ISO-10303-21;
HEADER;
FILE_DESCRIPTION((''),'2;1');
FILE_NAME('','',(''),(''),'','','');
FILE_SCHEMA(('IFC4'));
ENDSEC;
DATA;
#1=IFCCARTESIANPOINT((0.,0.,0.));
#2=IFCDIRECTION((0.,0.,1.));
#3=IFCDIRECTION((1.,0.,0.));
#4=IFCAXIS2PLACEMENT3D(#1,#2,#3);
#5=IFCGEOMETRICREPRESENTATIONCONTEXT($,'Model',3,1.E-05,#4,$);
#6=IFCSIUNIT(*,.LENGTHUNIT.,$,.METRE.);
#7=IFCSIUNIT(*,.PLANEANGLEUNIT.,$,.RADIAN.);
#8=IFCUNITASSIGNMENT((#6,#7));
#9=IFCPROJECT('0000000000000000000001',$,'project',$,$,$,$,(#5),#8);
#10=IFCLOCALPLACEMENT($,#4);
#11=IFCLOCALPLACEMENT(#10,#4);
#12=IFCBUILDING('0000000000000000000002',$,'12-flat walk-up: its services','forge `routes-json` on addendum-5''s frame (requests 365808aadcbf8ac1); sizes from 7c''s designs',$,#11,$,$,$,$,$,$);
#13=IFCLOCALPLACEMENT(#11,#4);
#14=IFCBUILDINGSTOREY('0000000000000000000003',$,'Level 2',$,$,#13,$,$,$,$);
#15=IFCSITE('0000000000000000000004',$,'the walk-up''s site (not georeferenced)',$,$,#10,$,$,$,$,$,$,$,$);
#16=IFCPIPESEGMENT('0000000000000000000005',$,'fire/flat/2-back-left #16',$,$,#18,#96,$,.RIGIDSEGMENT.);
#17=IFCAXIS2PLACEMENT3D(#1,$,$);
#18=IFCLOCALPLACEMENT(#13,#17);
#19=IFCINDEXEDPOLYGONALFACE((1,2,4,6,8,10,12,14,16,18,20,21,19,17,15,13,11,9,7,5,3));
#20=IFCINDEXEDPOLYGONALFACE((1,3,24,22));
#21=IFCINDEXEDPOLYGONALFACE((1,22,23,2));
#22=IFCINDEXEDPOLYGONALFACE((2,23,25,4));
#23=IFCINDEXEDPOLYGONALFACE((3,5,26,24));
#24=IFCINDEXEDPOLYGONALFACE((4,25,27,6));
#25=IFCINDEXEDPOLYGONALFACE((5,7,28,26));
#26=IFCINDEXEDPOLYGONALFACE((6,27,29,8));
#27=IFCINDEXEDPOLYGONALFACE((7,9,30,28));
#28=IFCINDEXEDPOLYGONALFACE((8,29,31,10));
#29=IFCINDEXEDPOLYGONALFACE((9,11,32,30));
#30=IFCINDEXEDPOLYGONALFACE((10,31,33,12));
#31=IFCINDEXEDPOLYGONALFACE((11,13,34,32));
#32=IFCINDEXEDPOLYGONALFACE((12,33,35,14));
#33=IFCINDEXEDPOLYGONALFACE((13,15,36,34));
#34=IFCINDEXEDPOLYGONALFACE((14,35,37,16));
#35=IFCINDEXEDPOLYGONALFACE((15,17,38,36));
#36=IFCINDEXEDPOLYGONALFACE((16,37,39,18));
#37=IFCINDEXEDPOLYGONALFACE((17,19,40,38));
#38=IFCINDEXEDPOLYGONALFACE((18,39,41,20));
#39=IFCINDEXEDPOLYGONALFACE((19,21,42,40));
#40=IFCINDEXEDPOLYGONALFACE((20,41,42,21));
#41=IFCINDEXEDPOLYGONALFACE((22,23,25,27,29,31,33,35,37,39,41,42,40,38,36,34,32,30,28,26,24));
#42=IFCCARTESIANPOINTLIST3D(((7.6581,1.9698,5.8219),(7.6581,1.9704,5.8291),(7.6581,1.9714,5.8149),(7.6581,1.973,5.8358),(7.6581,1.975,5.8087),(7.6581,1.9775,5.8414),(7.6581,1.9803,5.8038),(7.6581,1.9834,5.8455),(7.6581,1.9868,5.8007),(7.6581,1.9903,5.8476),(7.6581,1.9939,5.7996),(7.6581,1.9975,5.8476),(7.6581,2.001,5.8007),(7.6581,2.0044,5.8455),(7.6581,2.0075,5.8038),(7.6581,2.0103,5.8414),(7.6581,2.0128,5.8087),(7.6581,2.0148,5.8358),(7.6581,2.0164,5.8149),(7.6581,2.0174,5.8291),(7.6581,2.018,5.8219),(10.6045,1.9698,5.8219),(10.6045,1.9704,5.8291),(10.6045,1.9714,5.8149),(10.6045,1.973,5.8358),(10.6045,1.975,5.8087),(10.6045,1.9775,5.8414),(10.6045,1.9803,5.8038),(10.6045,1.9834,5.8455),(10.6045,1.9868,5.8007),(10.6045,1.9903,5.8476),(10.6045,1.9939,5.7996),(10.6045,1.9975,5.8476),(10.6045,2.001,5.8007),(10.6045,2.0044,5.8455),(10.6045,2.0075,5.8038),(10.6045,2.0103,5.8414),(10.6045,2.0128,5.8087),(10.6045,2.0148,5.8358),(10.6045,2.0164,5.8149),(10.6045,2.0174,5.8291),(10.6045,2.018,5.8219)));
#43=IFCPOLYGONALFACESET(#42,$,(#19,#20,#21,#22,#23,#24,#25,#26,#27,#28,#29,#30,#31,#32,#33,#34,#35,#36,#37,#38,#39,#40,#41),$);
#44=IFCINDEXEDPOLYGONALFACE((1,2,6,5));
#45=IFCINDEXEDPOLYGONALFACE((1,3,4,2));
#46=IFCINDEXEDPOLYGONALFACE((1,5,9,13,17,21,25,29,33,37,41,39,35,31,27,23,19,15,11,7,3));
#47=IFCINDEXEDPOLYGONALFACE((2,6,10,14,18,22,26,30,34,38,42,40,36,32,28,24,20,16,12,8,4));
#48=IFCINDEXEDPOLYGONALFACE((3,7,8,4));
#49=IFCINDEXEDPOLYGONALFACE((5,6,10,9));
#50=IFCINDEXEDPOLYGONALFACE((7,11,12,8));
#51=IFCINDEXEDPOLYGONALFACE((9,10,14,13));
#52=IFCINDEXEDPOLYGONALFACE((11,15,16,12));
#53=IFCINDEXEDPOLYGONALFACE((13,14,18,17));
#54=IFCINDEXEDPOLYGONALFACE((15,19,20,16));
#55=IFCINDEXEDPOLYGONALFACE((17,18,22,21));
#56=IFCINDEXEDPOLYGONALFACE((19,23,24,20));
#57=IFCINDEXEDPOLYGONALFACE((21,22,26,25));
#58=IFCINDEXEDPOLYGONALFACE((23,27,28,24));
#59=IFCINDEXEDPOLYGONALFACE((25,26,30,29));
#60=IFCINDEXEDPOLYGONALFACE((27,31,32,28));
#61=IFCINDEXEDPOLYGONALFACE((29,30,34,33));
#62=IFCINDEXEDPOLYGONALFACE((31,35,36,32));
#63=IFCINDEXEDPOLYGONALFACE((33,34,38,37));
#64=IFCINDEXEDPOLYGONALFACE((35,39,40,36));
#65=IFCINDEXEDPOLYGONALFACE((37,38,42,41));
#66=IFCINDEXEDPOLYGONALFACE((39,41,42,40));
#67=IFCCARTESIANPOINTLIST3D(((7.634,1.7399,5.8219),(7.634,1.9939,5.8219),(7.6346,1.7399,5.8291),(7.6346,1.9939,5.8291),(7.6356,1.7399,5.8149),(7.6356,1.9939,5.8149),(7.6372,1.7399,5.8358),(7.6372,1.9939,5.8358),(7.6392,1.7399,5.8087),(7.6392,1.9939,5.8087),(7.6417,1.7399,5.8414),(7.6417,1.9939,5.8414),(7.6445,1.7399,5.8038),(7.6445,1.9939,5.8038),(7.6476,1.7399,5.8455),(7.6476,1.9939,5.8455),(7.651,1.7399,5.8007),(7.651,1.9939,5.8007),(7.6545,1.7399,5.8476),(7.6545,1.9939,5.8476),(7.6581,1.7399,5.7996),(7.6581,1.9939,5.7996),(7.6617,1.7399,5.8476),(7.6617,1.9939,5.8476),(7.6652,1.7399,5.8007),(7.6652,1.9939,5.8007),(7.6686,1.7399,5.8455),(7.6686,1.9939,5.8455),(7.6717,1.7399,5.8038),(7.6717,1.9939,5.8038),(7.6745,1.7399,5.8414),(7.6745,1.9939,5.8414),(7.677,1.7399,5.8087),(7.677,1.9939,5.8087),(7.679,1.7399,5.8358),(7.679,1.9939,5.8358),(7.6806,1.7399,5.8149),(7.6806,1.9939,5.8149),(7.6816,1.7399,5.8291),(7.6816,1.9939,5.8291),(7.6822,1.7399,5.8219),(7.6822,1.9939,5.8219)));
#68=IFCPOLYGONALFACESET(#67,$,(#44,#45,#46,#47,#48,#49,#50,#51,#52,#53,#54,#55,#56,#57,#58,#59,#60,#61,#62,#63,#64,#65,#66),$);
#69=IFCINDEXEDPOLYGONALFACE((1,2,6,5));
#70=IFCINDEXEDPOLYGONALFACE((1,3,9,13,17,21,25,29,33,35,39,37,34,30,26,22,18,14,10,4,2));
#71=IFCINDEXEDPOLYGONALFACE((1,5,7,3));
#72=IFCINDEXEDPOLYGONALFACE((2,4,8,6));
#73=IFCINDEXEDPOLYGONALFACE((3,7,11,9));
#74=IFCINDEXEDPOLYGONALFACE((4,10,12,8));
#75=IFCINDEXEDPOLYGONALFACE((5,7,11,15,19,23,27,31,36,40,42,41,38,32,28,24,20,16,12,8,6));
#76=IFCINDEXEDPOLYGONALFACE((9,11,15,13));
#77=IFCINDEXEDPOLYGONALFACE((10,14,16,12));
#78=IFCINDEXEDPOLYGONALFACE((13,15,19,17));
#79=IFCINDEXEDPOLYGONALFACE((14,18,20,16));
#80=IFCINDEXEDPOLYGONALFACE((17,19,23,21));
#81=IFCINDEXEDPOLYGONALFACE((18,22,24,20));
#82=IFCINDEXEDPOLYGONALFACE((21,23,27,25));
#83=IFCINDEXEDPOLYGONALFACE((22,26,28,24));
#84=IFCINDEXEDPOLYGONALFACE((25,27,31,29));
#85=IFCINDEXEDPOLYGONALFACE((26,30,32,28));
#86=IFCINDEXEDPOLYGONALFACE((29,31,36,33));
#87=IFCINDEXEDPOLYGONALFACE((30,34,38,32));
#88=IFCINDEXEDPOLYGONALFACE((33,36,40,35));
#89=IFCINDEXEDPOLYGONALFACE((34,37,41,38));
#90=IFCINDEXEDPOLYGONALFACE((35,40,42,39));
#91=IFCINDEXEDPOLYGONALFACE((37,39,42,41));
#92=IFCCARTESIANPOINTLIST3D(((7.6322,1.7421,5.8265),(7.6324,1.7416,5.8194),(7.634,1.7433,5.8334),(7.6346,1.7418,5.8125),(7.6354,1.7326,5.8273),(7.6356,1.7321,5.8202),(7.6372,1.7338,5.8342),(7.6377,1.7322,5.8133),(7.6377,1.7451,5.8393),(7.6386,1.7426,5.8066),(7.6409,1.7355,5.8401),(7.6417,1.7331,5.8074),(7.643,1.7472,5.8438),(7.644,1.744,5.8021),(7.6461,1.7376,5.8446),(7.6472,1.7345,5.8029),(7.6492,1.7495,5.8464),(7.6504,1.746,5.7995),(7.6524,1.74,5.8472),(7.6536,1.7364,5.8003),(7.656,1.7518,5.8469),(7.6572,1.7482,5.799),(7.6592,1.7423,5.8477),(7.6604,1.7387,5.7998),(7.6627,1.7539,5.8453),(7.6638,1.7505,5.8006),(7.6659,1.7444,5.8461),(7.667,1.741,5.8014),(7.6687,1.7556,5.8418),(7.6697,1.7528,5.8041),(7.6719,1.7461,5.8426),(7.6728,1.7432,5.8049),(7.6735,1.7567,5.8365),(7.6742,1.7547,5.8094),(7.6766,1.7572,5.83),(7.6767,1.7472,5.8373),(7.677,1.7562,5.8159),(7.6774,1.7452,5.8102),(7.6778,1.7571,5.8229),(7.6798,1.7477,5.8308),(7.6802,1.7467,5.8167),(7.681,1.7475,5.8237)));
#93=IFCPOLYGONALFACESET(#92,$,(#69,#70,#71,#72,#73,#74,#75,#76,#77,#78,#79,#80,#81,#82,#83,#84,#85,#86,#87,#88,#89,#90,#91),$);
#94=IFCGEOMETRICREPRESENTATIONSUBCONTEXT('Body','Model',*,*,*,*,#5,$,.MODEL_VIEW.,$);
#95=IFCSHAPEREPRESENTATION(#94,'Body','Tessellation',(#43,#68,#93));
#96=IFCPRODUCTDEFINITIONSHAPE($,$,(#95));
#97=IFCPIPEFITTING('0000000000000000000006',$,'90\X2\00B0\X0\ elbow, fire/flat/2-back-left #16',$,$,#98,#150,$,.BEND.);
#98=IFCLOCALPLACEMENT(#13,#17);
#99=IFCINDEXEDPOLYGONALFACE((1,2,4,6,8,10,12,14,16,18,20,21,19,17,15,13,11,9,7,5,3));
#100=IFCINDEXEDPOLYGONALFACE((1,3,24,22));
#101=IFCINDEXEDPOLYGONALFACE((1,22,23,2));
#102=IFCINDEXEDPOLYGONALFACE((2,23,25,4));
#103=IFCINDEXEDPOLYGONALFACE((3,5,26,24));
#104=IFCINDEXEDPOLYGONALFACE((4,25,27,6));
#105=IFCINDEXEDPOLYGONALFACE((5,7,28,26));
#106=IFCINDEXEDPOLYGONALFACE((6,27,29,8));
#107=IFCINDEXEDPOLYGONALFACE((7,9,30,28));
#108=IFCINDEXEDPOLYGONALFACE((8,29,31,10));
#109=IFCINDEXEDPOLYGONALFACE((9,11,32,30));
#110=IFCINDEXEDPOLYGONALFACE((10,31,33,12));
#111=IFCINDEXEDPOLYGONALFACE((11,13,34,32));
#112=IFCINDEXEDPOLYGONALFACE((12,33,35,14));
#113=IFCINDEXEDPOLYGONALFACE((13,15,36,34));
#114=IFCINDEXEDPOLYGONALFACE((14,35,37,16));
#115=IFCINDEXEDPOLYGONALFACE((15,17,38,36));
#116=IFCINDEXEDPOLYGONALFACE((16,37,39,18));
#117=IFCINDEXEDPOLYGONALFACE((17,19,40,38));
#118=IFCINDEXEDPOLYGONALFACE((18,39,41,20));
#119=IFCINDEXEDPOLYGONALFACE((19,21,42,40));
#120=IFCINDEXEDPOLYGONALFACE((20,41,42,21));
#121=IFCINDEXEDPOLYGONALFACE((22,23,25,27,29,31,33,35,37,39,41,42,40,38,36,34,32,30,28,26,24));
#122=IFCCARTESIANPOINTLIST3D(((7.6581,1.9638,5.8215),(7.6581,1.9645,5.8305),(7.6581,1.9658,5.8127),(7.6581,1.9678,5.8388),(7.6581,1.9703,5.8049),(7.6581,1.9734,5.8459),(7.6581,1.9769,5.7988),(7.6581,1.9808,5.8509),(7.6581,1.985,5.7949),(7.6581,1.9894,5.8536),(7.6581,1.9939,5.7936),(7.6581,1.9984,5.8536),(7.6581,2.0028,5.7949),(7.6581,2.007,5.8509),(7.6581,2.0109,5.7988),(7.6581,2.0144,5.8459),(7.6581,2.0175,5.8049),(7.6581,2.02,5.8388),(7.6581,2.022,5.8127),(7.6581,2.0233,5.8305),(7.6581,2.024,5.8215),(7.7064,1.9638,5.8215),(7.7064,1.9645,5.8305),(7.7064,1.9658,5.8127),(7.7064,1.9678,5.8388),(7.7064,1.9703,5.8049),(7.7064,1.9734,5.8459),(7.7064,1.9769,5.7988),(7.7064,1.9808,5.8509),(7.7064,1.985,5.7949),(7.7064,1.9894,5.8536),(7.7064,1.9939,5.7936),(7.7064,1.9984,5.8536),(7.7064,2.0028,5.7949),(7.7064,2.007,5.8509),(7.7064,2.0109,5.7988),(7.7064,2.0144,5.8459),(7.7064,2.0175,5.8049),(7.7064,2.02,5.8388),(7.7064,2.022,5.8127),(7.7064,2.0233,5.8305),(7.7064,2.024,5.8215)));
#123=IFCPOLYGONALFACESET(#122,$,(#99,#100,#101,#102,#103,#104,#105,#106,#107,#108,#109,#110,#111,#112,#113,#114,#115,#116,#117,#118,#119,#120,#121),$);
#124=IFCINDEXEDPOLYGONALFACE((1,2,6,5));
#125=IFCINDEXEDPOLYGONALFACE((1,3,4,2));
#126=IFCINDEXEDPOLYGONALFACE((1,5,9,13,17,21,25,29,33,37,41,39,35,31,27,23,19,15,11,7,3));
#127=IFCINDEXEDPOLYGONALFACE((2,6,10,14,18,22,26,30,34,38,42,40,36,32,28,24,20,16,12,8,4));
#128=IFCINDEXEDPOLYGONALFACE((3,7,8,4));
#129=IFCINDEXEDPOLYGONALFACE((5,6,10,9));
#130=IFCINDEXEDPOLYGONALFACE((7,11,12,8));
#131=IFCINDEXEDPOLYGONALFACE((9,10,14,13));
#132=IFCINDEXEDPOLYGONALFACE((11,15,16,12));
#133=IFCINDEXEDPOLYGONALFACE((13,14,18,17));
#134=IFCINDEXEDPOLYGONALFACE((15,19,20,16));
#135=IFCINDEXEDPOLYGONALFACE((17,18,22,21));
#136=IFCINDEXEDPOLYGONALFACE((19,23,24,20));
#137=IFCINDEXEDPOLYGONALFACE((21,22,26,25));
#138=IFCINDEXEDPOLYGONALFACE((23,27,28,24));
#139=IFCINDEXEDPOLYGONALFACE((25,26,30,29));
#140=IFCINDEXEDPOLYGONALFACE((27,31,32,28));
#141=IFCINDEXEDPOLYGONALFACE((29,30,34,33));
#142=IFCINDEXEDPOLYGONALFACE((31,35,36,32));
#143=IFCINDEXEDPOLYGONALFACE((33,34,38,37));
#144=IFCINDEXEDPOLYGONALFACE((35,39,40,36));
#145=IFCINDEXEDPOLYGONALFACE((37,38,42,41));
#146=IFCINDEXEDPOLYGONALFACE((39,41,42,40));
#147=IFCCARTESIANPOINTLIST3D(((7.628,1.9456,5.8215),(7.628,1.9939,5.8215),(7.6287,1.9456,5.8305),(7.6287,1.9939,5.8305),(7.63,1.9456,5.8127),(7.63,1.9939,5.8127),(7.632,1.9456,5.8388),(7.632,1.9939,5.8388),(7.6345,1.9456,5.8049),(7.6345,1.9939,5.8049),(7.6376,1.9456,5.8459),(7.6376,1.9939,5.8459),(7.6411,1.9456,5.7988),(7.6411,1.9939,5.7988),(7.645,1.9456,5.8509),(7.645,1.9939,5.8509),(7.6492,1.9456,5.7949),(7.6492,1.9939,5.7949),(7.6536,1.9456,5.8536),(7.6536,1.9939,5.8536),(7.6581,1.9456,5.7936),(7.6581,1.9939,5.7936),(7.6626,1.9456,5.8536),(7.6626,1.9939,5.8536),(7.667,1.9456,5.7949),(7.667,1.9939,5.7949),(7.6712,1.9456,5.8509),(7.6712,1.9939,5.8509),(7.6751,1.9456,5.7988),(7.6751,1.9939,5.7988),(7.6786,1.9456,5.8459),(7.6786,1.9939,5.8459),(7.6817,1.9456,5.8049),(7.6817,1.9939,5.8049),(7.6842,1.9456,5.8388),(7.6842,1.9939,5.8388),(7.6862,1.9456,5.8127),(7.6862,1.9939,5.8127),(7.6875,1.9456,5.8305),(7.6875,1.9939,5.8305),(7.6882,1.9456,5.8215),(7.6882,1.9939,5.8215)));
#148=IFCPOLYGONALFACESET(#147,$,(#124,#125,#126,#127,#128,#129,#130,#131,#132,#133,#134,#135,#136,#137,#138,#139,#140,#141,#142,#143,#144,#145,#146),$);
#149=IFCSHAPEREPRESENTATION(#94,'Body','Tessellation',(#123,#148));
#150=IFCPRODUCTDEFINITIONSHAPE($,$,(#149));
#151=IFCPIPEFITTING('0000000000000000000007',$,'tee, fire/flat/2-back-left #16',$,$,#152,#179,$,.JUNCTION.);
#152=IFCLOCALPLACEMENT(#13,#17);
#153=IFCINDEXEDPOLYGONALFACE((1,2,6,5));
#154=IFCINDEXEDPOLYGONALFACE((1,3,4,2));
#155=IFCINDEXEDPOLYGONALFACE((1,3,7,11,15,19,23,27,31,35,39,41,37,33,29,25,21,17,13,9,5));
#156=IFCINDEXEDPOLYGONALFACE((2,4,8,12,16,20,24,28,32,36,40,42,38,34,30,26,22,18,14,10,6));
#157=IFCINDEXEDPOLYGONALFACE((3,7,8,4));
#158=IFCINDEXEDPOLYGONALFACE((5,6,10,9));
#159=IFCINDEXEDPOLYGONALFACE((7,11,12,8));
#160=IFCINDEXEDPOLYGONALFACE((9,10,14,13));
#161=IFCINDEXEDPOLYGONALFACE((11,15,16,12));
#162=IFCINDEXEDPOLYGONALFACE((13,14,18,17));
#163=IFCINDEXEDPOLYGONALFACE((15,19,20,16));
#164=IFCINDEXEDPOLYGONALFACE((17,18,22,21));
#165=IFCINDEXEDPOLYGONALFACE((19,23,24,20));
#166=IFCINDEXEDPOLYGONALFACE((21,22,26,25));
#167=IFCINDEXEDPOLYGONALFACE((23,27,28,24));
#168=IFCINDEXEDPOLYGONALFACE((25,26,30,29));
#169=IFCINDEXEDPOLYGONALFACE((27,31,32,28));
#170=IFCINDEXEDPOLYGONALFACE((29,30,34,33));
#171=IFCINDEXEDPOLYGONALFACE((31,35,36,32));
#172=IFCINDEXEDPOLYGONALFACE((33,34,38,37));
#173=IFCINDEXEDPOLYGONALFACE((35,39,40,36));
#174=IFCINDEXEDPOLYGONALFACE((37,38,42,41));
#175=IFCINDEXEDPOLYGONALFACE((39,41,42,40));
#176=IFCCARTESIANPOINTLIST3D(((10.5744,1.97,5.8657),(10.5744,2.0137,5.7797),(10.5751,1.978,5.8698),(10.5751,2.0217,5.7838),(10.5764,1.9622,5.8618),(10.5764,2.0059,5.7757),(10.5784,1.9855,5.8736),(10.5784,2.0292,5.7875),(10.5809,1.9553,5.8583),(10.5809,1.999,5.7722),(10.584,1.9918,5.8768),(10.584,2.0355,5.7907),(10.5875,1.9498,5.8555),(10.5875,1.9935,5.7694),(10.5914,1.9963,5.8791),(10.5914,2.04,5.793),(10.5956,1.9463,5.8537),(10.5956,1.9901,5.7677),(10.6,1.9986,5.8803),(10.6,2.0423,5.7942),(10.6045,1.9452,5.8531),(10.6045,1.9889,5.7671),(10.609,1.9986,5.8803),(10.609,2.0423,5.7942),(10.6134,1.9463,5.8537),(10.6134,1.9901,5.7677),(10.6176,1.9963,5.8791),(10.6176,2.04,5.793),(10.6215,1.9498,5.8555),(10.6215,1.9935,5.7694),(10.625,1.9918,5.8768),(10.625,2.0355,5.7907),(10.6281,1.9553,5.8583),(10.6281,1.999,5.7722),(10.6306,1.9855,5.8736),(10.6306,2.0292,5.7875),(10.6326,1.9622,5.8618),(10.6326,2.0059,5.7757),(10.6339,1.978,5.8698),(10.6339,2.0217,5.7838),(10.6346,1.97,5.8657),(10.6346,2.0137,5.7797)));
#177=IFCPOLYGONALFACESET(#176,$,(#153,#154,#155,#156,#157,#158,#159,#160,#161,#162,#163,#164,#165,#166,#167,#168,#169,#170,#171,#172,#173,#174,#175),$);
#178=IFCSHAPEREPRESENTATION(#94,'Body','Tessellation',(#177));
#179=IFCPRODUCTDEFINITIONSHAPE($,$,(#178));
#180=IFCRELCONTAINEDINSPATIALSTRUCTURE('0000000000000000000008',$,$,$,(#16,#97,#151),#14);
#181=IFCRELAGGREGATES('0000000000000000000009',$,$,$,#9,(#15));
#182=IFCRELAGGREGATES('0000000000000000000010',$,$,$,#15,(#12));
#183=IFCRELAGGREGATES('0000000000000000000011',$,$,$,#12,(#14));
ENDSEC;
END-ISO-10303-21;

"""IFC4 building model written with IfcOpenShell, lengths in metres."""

from ifc_helpers import new_model, entity, si_unit, frame, origin_with_axes, place, context, subcontext, project, spatial, element, save


model = new_model("IFC4")

# Units and contexts
model_context = context("Model", 3, precision=1e-05, world=origin_with_axes())
body_context = subcontext(model_context, "Body", "Model", "MODEL_VIEW")
ifc_project = project(units=[si_unit("LENGTHUNIT", "METRE"), si_unit("PLANEANGLEUNIT", "RADIAN")], contexts=[model_context])

# Site, building, storey
site_placement = place(None, origin_with_axes())
site = spatial("IfcSite", under=ifc_project, at=site_placement, Name="the walk-up's site (not georeferenced)")
building_placement = place(site_placement, origin_with_axes())
building = spatial("IfcBuilding", under=site, at=building_placement, Name="12-flat walk-up: its services", Description="forge `routes-json` on addendum-5's frame (requests 365808aadcbf8ac1); sizes from 7c's designs")
storey_placement = place(building_placement, origin_with_axes())
storey = spatial("IfcBuildingStorey", under=building, at=storey_placement, Name="Level 2")

# Pipe segment
pipe_segment_1_placement = place(storey_placement, frame((10.6045, 1.9939, 5.8237), z_axis=(0.0, 0.0, 1.0), x_axis=(1.0, 0.0, 0.0)))
element("IfcPipeSegment", 1, at=pipe_segment_1_placement, inside=storey, Name="fire/flat/2-back-left #16", PredefinedType="RIGIDSEGMENT", context=body_context, shape_type="AdvancedSweptSolid", body=[
    entity("IfcSweptDiskSolid", entity("IfcPolyline", [entity("IfcCartesianPoint", [0.0, 0.0, 0.0]), entity("IfcCartesianPoint", [-2.9464, 0.0, 0.0])]), 0.0241),
    entity("IfcSweptDiskSolid", entity("IfcPolyline", [entity("IfcCartesianPoint", [-2.9464, 0.0, 0.0]), entity("IfcCartesianPoint", [-2.9464, -0.254, 0.0])]), 0.0241),
    entity("IfcSweptDiskSolid", entity("IfcPolyline", [entity("IfcCartesianPoint", [-2.9464, -0.254, 0.0]), entity("IfcCartesianPoint", [-2.9496, -0.2445, -0.0008])]), 0.0241),
])

# Pipe fittings
pipe_fitting_1_placement = place(storey_placement, frame((7.7064, 1.9939, 5.8237), z_axis=(0.0, 0.0, 1.0), x_axis=(1.0, 0.0, 0.0)))
element("IfcPipeFitting", 2, at=pipe_fitting_1_placement, inside=storey, Name="90° elbow, fire/flat/2-back-left #16", PredefinedType="BEND", context=body_context, shape_type="AdvancedSweptSolid", body=[
    entity("IfcSweptDiskSolid", entity("IfcPolyline", [entity("IfcCartesianPoint", [0.0, 0.0, 0.0]), entity("IfcCartesianPoint", [-0.0483, 0.0, 0.0])]), 0.0302),
    entity("IfcSweptDiskSolid", entity("IfcPolyline", [entity("IfcCartesianPoint", [-0.0483, 0.0, 0.0]), entity("IfcCartesianPoint", [-0.0483, -0.0483, 0.0])]), 0.0302),
])
pipe_fitting_2_placement = place(storey_placement, frame((10.6045, 1.972, 5.8668), z_axis=(0.0, 0.0, 1.0), x_axis=(1.0, 0.0, 0.0)))
element("IfcPipeFitting", 3, at=pipe_fitting_2_placement, inside=storey, Name="tee, fire/flat/2-back-left #16", PredefinedType="JUNCTION", context=body_context, shape_type="AdvancedSweptSolid", body=[
    entity("IfcSweptDiskSolid", entity("IfcPolyline", [entity("IfcCartesianPoint", [0.0, 0.0, 0.0]), entity("IfcCartesianPoint", [0.0, 0.0437, -0.0861])]), 0.0302),
])

save(model, "model.ifc")
